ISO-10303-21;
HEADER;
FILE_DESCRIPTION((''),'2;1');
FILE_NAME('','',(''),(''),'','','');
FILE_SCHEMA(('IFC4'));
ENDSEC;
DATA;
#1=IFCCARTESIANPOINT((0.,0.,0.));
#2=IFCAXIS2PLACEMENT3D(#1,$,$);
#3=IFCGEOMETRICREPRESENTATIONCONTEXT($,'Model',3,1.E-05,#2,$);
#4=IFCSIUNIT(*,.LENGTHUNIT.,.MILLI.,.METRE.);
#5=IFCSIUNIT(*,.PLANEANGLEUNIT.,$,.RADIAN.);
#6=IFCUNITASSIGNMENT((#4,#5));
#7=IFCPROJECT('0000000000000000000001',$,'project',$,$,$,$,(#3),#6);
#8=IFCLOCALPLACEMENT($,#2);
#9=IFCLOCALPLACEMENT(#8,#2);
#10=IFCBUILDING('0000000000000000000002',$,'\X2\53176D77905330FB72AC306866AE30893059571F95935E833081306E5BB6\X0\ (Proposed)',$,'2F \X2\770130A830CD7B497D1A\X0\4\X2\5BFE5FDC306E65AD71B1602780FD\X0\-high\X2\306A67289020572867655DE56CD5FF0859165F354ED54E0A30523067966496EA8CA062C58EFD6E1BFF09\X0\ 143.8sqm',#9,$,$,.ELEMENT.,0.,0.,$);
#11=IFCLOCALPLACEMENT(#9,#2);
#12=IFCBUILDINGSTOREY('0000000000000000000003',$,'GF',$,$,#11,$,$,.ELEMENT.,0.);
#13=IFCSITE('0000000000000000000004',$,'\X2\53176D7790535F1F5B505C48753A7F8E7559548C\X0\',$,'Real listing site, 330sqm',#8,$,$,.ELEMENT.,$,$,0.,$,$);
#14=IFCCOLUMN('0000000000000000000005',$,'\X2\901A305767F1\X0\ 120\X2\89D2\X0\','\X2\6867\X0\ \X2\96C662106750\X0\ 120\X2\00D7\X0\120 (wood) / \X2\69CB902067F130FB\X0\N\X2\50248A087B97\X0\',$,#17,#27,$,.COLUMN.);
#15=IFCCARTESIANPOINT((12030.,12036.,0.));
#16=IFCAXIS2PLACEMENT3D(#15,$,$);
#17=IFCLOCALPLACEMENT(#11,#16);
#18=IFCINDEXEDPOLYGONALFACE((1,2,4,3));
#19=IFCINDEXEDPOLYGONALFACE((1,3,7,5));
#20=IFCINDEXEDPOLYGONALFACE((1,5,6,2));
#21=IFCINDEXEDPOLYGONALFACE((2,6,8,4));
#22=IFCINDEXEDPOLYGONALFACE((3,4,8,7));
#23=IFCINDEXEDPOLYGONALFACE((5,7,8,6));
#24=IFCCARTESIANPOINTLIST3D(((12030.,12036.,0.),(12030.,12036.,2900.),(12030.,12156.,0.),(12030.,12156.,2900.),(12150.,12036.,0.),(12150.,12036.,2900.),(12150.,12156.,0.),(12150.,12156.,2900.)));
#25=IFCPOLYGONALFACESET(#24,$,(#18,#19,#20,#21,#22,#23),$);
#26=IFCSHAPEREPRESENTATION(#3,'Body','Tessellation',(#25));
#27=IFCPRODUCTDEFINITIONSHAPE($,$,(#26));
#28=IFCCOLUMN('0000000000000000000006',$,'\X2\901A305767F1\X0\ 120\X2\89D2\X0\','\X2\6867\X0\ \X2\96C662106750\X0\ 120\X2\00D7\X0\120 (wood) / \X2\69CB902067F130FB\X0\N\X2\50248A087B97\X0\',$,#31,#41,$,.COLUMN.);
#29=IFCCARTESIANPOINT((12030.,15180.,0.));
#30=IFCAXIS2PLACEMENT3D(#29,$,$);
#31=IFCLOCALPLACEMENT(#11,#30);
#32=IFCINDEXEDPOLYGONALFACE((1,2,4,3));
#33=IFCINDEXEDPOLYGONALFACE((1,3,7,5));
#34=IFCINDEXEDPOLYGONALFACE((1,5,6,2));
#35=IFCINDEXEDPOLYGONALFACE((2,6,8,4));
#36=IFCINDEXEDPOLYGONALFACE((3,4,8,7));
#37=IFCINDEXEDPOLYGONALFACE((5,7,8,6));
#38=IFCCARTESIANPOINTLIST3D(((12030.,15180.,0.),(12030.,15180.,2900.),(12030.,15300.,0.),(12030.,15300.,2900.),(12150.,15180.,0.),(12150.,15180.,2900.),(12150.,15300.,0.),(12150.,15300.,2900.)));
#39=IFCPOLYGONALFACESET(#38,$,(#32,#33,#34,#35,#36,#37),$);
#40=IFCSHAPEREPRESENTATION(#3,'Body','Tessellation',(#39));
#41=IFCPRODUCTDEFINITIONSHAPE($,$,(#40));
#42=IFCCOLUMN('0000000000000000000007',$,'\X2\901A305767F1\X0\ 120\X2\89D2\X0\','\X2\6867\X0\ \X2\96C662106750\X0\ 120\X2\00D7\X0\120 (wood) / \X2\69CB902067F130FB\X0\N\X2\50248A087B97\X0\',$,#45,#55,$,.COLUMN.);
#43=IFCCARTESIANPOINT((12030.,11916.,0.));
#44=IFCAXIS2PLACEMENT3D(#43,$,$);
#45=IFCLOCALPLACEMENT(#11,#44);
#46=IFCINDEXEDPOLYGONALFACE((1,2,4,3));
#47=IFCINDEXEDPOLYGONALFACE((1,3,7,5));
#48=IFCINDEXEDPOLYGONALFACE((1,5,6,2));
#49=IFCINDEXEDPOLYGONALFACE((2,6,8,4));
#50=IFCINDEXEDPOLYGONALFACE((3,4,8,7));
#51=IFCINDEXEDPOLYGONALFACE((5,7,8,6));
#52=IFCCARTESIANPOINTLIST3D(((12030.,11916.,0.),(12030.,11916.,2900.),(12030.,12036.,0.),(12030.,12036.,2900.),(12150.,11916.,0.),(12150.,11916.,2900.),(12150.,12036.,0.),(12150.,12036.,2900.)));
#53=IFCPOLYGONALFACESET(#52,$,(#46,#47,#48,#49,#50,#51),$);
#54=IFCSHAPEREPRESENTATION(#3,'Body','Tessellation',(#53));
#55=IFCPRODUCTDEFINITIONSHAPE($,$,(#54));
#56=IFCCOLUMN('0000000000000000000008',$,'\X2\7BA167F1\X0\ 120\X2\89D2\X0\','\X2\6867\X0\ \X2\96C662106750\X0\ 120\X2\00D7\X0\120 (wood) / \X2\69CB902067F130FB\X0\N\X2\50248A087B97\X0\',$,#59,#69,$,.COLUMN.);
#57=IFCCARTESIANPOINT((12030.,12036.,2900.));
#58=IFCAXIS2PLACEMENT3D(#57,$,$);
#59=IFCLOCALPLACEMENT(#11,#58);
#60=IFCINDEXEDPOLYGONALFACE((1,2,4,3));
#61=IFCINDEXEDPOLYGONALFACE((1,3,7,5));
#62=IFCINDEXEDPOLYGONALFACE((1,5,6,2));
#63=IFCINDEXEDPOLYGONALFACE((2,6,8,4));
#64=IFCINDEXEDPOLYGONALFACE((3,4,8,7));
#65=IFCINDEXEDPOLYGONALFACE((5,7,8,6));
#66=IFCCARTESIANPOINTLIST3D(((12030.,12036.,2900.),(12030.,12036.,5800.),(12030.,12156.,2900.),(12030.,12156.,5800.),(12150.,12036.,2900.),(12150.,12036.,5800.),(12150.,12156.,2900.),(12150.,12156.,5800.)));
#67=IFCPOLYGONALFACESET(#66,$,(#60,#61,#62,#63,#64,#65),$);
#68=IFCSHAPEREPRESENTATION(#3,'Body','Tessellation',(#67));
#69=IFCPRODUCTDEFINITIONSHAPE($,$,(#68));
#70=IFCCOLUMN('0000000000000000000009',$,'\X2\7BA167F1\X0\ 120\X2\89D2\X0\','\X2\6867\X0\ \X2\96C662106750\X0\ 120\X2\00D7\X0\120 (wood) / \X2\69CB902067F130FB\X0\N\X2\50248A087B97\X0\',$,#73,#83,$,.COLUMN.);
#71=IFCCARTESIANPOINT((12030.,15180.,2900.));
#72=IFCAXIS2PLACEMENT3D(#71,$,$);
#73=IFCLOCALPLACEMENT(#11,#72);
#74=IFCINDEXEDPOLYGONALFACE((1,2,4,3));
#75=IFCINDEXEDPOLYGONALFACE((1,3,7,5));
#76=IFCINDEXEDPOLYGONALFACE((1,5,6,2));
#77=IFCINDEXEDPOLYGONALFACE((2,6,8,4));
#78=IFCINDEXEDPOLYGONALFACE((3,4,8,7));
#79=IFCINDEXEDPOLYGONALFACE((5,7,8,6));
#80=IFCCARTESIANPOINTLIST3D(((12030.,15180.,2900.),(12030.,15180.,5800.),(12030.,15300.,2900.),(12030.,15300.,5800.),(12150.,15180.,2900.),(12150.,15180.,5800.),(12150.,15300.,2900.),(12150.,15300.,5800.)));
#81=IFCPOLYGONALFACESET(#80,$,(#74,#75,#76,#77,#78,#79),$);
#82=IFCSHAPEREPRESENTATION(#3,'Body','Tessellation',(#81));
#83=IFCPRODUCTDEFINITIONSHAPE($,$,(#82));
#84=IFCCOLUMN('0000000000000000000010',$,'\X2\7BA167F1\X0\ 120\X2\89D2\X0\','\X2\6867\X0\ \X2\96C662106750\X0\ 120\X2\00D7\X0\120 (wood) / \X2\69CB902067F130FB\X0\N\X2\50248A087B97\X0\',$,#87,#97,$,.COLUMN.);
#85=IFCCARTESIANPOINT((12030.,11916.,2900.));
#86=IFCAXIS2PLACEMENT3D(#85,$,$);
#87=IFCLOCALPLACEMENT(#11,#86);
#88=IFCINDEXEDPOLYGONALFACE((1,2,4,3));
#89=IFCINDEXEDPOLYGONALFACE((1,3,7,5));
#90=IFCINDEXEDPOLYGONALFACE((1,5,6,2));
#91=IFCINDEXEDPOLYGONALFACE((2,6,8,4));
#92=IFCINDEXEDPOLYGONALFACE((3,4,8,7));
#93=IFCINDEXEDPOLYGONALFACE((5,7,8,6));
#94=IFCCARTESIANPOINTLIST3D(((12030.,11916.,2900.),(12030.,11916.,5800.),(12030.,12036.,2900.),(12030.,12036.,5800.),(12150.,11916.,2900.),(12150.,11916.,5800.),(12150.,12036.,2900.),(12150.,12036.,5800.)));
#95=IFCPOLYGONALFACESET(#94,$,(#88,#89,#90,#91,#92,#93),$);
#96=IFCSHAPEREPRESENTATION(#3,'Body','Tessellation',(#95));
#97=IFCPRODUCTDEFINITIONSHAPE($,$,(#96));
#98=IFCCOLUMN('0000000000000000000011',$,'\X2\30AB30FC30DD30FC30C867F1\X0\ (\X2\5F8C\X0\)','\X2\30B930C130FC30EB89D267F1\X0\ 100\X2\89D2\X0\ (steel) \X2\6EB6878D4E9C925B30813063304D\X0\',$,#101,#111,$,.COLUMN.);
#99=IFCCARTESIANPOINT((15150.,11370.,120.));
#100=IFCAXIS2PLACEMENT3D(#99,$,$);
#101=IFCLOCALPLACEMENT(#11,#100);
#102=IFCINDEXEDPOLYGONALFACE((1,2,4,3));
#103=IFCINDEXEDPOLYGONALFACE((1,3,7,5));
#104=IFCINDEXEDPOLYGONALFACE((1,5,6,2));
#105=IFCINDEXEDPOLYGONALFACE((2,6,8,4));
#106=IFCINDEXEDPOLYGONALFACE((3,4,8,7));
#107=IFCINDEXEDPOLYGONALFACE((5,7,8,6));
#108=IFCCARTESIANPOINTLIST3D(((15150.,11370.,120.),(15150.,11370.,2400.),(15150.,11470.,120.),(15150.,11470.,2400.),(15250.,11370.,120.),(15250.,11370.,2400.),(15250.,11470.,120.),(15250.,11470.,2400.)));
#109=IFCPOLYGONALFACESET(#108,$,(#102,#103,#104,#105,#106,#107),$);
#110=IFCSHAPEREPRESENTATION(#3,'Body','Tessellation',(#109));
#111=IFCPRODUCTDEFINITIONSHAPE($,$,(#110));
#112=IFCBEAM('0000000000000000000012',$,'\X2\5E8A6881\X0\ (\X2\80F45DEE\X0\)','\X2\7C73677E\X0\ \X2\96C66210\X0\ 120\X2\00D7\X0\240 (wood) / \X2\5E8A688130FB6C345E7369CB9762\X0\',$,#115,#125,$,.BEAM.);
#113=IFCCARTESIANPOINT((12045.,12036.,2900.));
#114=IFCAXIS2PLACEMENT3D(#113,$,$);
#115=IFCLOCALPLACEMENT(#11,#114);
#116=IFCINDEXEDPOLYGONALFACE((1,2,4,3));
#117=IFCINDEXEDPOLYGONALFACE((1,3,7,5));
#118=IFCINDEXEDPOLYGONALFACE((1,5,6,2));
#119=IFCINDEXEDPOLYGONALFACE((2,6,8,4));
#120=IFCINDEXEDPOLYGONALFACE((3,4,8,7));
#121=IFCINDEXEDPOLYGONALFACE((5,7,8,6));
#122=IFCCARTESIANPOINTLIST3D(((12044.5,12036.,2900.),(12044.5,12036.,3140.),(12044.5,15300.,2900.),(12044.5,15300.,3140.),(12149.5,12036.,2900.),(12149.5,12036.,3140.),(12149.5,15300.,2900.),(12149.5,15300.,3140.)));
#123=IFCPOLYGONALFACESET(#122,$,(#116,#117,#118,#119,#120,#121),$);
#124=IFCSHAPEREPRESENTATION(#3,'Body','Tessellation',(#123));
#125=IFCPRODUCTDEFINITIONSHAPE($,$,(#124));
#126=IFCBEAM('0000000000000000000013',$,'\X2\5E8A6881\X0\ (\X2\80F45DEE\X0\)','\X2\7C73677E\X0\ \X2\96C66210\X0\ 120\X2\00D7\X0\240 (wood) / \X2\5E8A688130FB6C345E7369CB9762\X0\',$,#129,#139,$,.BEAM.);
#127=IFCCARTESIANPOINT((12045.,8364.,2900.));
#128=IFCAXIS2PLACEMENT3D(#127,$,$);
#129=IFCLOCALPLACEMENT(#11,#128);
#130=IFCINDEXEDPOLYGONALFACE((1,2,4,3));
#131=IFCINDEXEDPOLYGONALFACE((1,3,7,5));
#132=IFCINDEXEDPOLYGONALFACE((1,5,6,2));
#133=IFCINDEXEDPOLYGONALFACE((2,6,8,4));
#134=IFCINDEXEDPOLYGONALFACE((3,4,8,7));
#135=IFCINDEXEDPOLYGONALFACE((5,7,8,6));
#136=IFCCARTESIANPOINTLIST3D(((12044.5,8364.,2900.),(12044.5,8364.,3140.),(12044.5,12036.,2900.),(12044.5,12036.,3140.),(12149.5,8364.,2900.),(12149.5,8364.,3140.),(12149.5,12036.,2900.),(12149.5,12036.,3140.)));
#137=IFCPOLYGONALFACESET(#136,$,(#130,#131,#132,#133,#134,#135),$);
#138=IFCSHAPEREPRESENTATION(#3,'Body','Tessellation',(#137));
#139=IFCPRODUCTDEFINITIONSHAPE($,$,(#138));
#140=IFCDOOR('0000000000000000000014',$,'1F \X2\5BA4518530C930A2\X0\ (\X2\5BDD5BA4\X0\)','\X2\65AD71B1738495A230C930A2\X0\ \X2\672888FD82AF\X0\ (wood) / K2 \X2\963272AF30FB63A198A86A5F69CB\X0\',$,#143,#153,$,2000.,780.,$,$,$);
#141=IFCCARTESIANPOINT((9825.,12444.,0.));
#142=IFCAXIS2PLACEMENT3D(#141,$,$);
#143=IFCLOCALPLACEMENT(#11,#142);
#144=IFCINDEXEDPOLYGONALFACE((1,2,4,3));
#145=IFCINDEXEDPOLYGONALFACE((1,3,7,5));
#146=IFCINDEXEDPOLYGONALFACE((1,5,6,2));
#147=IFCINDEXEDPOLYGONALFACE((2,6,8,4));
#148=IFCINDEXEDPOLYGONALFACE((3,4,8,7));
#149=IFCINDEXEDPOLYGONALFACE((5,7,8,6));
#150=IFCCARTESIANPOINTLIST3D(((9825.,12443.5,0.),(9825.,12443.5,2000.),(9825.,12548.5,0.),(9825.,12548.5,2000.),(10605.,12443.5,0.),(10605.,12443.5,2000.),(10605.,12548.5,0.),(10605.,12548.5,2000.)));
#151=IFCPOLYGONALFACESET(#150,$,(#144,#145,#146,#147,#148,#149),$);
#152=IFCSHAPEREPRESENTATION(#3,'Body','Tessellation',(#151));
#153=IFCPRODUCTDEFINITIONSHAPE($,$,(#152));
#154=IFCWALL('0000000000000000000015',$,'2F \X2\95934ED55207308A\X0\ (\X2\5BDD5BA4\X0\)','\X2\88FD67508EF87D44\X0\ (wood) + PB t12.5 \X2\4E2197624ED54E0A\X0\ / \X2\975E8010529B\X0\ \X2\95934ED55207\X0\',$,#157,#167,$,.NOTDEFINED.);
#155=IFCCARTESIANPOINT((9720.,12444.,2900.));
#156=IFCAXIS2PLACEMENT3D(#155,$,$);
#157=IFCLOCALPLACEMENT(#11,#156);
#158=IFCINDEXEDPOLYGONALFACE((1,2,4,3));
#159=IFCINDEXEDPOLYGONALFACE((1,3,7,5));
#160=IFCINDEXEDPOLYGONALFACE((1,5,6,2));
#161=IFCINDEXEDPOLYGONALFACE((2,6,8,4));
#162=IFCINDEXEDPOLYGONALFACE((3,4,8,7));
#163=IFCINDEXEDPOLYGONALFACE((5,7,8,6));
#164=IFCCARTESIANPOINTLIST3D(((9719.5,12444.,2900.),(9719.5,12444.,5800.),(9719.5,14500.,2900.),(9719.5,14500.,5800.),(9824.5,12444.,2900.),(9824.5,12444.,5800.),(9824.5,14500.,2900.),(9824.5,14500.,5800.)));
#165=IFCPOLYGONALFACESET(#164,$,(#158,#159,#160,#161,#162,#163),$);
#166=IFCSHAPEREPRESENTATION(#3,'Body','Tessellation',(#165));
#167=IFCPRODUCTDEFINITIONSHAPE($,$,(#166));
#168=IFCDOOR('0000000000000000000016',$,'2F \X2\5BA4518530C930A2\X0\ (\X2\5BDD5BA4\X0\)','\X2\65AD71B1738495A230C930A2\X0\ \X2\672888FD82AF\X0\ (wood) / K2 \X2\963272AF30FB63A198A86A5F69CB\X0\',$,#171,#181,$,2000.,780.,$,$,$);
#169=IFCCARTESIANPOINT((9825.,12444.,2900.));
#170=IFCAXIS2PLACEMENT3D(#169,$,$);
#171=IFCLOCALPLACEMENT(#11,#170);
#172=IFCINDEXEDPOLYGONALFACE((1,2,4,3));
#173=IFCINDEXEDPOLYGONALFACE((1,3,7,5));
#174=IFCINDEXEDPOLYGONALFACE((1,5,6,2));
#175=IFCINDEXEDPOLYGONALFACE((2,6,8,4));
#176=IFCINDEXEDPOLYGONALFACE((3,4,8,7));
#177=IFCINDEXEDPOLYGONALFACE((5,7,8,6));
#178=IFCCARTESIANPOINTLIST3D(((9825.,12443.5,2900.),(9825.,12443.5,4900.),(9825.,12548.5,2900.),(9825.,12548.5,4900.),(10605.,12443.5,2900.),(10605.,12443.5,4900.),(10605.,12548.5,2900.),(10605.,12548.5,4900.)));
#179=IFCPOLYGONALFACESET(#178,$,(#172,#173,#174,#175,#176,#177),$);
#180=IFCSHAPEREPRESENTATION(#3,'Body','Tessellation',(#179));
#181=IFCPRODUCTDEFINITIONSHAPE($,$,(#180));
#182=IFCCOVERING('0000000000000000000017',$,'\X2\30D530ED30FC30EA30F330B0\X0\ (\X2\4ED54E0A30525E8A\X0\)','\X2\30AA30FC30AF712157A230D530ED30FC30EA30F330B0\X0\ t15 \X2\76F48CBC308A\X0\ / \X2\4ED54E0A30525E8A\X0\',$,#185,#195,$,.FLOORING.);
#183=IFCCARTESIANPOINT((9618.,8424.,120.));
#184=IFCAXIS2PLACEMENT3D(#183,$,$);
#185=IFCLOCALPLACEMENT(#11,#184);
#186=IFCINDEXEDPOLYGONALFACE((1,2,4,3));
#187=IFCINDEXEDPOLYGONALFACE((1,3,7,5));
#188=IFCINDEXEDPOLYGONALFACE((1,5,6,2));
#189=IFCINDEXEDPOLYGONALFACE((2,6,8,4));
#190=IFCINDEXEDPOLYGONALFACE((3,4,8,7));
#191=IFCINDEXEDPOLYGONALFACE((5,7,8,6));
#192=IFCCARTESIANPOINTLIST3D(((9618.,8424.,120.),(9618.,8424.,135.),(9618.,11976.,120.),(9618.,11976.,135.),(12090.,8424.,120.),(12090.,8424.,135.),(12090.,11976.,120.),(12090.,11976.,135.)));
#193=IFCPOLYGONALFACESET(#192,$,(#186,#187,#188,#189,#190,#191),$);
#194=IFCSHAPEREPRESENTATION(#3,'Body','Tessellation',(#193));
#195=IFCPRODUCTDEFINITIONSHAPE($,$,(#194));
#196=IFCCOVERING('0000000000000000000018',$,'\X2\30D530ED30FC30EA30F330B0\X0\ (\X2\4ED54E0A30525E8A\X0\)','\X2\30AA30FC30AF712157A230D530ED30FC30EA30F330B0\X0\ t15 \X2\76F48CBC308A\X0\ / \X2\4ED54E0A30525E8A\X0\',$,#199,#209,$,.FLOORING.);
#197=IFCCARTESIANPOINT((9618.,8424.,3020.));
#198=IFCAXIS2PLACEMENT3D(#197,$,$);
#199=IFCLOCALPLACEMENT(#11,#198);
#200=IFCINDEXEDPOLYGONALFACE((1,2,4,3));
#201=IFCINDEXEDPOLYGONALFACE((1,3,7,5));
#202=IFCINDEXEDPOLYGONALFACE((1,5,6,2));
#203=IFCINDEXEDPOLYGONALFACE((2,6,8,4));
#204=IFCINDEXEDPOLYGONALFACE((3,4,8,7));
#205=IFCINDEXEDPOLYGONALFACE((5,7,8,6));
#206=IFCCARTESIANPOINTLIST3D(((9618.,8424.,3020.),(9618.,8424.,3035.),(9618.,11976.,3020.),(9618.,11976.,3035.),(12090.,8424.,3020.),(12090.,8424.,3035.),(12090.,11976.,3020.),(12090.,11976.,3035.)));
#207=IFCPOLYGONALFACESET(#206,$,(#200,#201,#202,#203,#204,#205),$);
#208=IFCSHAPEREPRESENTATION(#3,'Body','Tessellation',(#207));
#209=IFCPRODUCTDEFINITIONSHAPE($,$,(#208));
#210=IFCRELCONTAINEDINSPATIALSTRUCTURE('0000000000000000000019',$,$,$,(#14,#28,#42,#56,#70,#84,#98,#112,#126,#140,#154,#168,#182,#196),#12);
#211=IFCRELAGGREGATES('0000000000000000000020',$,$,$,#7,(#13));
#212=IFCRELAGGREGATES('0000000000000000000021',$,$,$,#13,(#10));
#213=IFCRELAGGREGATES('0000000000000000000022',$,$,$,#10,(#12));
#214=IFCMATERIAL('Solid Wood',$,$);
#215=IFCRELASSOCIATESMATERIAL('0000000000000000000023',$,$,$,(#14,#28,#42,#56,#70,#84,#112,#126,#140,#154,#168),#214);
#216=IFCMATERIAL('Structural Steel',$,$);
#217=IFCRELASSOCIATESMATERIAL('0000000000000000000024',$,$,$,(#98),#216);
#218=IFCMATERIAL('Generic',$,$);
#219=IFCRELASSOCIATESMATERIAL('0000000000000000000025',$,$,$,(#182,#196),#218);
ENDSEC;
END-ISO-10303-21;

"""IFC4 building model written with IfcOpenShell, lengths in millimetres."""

from ifc_helpers import new_model, si_unit, frame, frame_2d, origin, place, context, project, spatial, rectangle, extrude, material, element, save


model = new_model("IFC4")

# Units and contexts
model_context = context("Model", 3, precision=1e-05, world=origin())
ifc_project = project(units=[si_unit("LENGTHUNIT", "METRE", prefix="MILLI"), si_unit("PLANEANGLEUNIT", "RADIAN")], contexts=[model_context])

# Site, building, storey
site_placement = place(None, origin())
site = spatial("IfcSite", under=ifc_project, at=site_placement, Name="北海道弟子屈町美留和", ObjectType="Real listing site, 330sqm", CompositionType="ELEMENT", RefElevation=0.0)
building_placement = place(site_placement, origin())
building = spatial("IfcBuilding", under=site, at=building_placement, Name="北海道・犬と暮らす土間広めの家 (Proposed)", ObjectType="2F 省エネ等級4対応の断熱性能-highな木造在来工法（外張仕上げで除雪負担軽減） 143.8sqm", CompositionType="ELEMENT", ElevationOfRefHeight=0.0, ElevationOfTerrain=0.0)
storey_placement = place(building_placement, origin())
storey = spatial("IfcBuildingStorey", under=building, at=storey_placement, Name="GF", CompositionType="ELEMENT", Elevation=0.0)

# Columns
ifc_material_1 = material(Name="Solid Wood")
column_1_placement = place(storey_placement, frame((12030.0, 12036.0, 0.0)))
element("IfcColumn", 1, at=column_1_placement, inside=storey, material=ifc_material_1, Name="通し柱 120角", Description="桧 集成材 120×120 (wood) / 構造柱・N値計算", PredefinedType="COLUMN", context=model_context, shape_type="SweptSolid", body=[
    extrude(rectangle(XDim=120.0, YDim=120.0, at=frame_2d((60.0, 60.0))), frame((12030.0, 12036.0, 0.0)), (0.0, 0.0, 1.0), 2900.0),
])
column_2_placement = place(storey_placement, frame((12030.0, 15180.0, 0.0)))
element("IfcColumn", 2, at=column_2_placement, inside=storey, material=ifc_material_1, Name="通し柱 120角", Description="桧 集成材 120×120 (wood) / 構造柱・N値計算", PredefinedType="COLUMN", context=model_context, shape_type="SweptSolid", body=[
    extrude(rectangle(XDim=120.0, YDim=120.0, at=frame_2d((60.0, 60.0))), frame((12030.0, 15180.0, 0.0)), (0.0, 0.0, 1.0), 2900.0),
])
column_3_placement = place(storey_placement, frame((12030.0, 11916.0, 0.0)))
element("IfcColumn", 3, at=column_3_placement, inside=storey, material=ifc_material_1, Name="通し柱 120角", Description="桧 集成材 120×120 (wood) / 構造柱・N値計算", PredefinedType="COLUMN", context=model_context, shape_type="SweptSolid", body=[
    extrude(rectangle(XDim=120.0, YDim=120.0, at=frame_2d((60.0, 60.0))), frame((12030.0, 11916.0, 0.0)), (0.0, 0.0, 1.0), 2900.0),
])
column_4_placement = place(storey_placement, frame((12030.0, 12036.0, 2900.0)))
element("IfcColumn", 4, at=column_4_placement, inside=storey, material=ifc_material_1, Name="管柱 120角", Description="桧 集成材 120×120 (wood) / 構造柱・N値計算", PredefinedType="COLUMN", context=model_context, shape_type="SweptSolid", body=[
    extrude(rectangle(XDim=120.0, YDim=120.0, at=frame_2d((60.0, 60.0))), frame((12030.0, 12036.0, 2900.0)), (0.0, 0.0, 1.0), 2900.0),
])
column_5_placement = place(storey_placement, frame((12030.0, 15180.0, 2900.0)))
element("IfcColumn", 5, at=column_5_placement, inside=storey, material=ifc_material_1, Name="管柱 120角", Description="桧 集成材 120×120 (wood) / 構造柱・N値計算", PredefinedType="COLUMN", context=model_context, shape_type="SweptSolid", body=[
    extrude(rectangle(XDim=120.0, YDim=120.0, at=frame_2d((60.0, 60.0))), frame((12030.0, 15180.0, 2900.0)), (0.0, 0.0, 1.0), 2900.0),
])
column_6_placement = place(storey_placement, frame((12030.0, 11916.0, 2900.0)))
element("IfcColumn", 6, at=column_6_placement, inside=storey, material=ifc_material_1, Name="管柱 120角", Description="桧 集成材 120×120 (wood) / 構造柱・N値計算", PredefinedType="COLUMN", context=model_context, shape_type="SweptSolid", body=[
    extrude(rectangle(XDim=120.0, YDim=120.0, at=frame_2d((60.0, 60.0))), frame((12030.0, 11916.0, 2900.0)), (0.0, 0.0, 1.0), 2900.0),
])
ifc_material_2 = material(Name="Structural Steel")
column_7_placement = place(storey_placement, frame((15150.0, 11370.0, 120.0)))
element("IfcColumn", 7, at=column_7_placement, inside=storey, material=ifc_material_2, Name="カーポート柱 (後)", Description="スチール角柱 100角 (steel) 溶融亜鉛めっき", PredefinedType="COLUMN", context=model_context, shape_type="SweptSolid", body=[
    extrude(rectangle(XDim=100.0, YDim=100.0, at=frame_2d((50.0, 50.0))), frame((15150.0, 11370.0, 120.0)), (0.0, 0.0, 1.0), 2280.0),
])

# Beams
beam_1_placement = place(storey_placement, frame((12045.0, 12036.0, 2900.0)))
element("IfcBeam", 8, at=beam_1_placement, inside=storey, material=ifc_material_1, Name="床梁 (胴差)", Description="米松 集成 120×240 (wood) / 床梁・水平構面", PredefinedType="BEAM", context=model_context, shape_type="SweptSolid", body=[
    extrude(rectangle(XDim=105.0, YDim=3264.0, at=frame_2d((52.0, 1632.0))), frame((12045.0, 12036.0, 2900.0)), (0.0, 0.0, 1.0), 240.0),
])
beam_2_placement = place(storey_placement, frame((12045.0, 8364.0, 2900.0)))
element("IfcBeam", 9, at=beam_2_placement, inside=storey, material=ifc_material_1, Name="床梁 (胴差)", Description="米松 集成 120×240 (wood) / 床梁・水平構面", PredefinedType="BEAM", context=model_context, shape_type="SweptSolid", body=[
    extrude(rectangle(XDim=105.0, YDim=3672.0, at=frame_2d((52.0, 1836.0))), frame((12045.0, 8364.0, 2900.0)), (0.0, 0.0, 1.0), 240.0),
])

# Door
door_1_placement = place(storey_placement, frame((9825.0, 12444.0, 0.0)))
element("IfcDoor", 10, at=door_1_placement, inside=storey, material=ifc_material_1, Name="1F 室内ドア (寝室)", Description="断熱玄関ドア 木製芯 (wood) / K2 防犯・採風機構", OverallHeight=2000.0, OverallWidth=780.0, context=model_context, shape_type="SweptSolid", body=[
    extrude(rectangle(XDim=780.0, YDim=105.0, at=frame_2d((390.0, 52.0))), frame((9825.0, 12444.0, 0.0)), (0.0, 0.0, 1.0), 2000.0),
])

# Wall
wall_1_placement = place(storey_placement, frame((9720.0, 12444.0, 2900.0)))
element("IfcWall", 11, at=wall_1_placement, inside=storey, material=ifc_material_1, Name="2F 間仕切り (寝室)", Description="製材軸組 (wood) + PB t12.5 両面仕上 / 非耐力 間仕切", PredefinedType="NOTDEFINED", context=model_context, shape_type="SweptSolid", body=[
    extrude(rectangle(XDim=105.0, YDim=2056.0, at=frame_2d((52.0, 1028.0))), frame((9720.0, 12444.0, 2900.0)), (0.0, 0.0, 1.0), 2900.0),
])

# Door
door_2_placement = place(storey_placement, frame((9825.0, 12444.0, 2900.0)))
element("IfcDoor", 12, at=door_2_placement, inside=storey, material=ifc_material_1, Name="2F 室内ドア (寝室)", Description="断熱玄関ドア 木製芯 (wood) / K2 防犯・採風機構", OverallHeight=2000.0, OverallWidth=780.0, context=model_context, shape_type="SweptSolid", body=[
    extrude(rectangle(XDim=780.0, YDim=105.0, at=frame_2d((390.0, 52.0))), frame((9825.0, 12444.0, 2900.0)), (0.0, 0.0, 1.0), 2000.0),
])

# Coverings
ifc_material_3 = material(Name="Generic")
covering_1_placement = place(storey_placement, frame((9618.0, 8424.0, 120.0)))
element("IfcCovering", 13, at=covering_1_placement, inside=storey, material=ifc_material_3, Name="フローリング (仕上げ床)", Description="オーク無垢フローリング t15 直貼り / 仕上げ床", PredefinedType="FLOORING", context=model_context, shape_type="SweptSolid", body=[
    extrude(rectangle(XDim=2472.0, YDim=3552.0, at=frame_2d((1236.0, 1776.0))), frame((9618.0, 8424.0, 120.0)), (0.0, 0.0, 1.0), 15.0),
])
covering_2_placement = place(storey_placement, frame((9618.0, 8424.0, 3020.0)))
element("IfcCovering", 14, at=covering_2_placement, inside=storey, material=ifc_material_3, Name="フローリング (仕上げ床)", Description="オーク無垢フローリング t15 直貼り / 仕上げ床", PredefinedType="FLOORING", context=model_context, shape_type="SweptSolid", body=[
    extrude(rectangle(XDim=2472.0, YDim=3552.0, at=frame_2d((1236.0, 1776.0))), frame((9618.0, 8424.0, 3020.0)), (0.0, 0.0, 1.0), 15.0),
])

save(model, "model.ifc")
